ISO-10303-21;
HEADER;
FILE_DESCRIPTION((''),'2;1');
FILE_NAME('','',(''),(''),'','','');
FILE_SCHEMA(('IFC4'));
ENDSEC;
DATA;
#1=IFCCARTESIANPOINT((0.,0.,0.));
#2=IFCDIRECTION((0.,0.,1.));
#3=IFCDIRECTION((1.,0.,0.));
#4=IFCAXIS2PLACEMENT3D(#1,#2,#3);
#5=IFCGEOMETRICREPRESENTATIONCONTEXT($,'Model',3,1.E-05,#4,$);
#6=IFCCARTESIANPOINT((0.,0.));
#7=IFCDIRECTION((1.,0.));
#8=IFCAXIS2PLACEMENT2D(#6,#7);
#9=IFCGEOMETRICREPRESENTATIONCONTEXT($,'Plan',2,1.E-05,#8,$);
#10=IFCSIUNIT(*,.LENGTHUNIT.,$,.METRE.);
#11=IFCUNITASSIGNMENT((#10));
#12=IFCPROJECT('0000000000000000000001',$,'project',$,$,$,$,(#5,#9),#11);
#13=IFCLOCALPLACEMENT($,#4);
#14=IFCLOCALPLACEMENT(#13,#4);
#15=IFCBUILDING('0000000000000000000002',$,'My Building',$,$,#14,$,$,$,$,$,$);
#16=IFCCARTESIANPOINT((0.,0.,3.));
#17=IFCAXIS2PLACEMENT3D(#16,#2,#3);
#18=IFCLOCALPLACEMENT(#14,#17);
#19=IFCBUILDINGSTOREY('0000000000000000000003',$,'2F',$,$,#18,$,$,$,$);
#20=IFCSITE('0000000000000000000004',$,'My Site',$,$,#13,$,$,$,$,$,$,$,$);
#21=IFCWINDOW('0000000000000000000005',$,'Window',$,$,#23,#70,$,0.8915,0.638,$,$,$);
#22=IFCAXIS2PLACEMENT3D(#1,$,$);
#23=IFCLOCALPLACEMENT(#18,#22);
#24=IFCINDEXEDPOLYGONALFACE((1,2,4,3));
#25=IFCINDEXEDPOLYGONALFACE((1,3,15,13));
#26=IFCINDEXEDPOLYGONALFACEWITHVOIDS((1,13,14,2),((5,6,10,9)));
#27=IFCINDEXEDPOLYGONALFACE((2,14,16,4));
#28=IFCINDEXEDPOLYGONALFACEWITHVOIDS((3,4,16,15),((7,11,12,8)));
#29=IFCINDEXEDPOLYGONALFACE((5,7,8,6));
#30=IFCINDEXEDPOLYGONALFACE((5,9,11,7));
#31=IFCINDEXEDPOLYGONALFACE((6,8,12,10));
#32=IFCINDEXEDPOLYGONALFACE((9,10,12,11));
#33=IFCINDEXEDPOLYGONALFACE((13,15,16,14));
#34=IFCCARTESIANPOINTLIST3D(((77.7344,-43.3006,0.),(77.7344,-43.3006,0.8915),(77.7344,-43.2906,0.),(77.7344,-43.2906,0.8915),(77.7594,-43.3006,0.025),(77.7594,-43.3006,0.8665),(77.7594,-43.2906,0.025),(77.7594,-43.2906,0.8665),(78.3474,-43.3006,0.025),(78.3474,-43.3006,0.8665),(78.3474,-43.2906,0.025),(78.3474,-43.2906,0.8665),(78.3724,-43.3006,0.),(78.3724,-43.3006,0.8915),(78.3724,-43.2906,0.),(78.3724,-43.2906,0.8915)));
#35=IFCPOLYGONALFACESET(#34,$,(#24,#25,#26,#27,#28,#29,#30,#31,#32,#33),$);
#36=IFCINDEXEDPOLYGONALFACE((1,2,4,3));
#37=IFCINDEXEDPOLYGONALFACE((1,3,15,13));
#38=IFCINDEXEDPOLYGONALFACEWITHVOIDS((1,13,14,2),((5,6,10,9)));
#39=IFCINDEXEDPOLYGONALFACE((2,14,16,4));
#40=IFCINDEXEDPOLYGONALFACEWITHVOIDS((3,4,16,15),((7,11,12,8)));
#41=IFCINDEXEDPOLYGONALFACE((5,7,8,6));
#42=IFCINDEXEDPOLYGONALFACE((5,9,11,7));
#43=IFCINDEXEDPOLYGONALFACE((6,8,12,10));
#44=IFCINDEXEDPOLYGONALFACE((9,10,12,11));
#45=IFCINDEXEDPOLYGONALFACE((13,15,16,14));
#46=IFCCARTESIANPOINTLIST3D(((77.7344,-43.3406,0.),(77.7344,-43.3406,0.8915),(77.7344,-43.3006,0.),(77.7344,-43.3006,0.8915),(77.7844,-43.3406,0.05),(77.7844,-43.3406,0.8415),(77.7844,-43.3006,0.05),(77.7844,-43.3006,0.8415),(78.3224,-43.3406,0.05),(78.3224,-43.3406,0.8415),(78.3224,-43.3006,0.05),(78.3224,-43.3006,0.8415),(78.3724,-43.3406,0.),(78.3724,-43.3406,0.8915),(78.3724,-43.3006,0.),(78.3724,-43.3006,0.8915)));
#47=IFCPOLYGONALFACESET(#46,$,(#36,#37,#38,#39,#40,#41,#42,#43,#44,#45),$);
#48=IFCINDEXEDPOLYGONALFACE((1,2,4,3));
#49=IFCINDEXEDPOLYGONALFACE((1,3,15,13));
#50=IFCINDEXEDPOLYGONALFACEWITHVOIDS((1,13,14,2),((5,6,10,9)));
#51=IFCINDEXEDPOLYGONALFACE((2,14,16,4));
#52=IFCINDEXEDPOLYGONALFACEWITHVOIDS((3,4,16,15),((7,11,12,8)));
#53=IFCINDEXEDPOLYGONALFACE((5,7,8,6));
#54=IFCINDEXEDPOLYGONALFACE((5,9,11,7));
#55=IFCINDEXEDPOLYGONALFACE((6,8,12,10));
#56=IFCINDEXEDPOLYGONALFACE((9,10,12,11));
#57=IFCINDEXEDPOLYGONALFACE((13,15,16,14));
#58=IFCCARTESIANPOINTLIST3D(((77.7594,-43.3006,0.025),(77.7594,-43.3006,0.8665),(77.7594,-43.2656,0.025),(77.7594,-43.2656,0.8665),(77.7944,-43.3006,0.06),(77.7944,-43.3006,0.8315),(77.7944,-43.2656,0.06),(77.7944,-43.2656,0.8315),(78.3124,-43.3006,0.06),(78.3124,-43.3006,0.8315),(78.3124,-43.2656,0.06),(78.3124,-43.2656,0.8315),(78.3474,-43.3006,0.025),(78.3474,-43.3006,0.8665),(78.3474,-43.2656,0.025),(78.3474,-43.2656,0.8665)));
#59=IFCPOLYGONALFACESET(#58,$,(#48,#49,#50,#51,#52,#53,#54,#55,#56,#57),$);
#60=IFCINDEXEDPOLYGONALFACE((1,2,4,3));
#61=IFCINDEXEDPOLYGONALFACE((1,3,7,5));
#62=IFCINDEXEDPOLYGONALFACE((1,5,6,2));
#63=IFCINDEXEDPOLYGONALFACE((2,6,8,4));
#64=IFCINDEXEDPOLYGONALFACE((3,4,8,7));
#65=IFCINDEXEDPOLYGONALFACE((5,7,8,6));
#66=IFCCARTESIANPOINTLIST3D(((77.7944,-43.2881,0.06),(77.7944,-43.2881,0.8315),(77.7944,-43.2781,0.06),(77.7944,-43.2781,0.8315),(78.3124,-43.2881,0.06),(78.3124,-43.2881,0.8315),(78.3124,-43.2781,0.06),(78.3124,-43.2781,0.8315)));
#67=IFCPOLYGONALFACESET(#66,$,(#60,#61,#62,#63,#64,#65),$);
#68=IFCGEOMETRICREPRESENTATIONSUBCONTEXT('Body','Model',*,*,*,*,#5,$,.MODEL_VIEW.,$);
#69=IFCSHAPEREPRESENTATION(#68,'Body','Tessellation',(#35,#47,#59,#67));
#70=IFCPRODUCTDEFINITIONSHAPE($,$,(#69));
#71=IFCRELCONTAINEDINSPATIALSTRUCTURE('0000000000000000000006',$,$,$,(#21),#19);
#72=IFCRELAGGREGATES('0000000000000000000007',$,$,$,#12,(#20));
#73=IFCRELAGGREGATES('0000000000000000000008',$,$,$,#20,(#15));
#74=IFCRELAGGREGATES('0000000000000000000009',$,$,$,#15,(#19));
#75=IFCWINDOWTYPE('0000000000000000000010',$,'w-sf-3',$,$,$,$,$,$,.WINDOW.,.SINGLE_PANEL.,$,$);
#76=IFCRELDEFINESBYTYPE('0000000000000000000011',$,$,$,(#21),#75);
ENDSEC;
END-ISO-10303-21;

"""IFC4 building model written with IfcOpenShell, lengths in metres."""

from ifc_helpers import new_model, entity, si_unit, frame, origin_with_axes, origin_2d_with_axis, place, context, subcontext, project, spatial, line, indexed_curve, outline, extrude, shape, source, transform, mapped, type_object, type_shapes, element, save


model = new_model("IFC4")

# Units and contexts
model_context = context("Model", 3, precision=1e-05, world=origin_with_axes())
plan_context = context("Plan", 2, precision=1e-05, world=origin_2d_with_axis())
body_context_1 = subcontext(model_context, "Body", "Model", "MODEL_VIEW")
body_context_2 = subcontext(plan_context, "Body", "Plan", "PLAN_VIEW")
ifc_project = project(units=[si_unit("LENGTHUNIT", "METRE")], contexts=[model_context, plan_context])

# Site, building, storey
site_placement = place(None, origin_with_axes())
site = spatial("IfcSite", under=ifc_project, at=site_placement, Name="My Site")
building_placement = place(site_placement, origin_with_axes())
building = spatial("IfcBuilding", under=site, at=building_placement, Name="My Building")
storey_placement = place(building_placement, frame((0.0, 0.0, 3.0), z_axis=(0.0, 0.0, 1.0), x_axis=(1.0, 0.0, 0.0)))
storey = spatial("IfcBuildingStorey", under=building, at=storey_placement, Name="2F")

# Window
window_type_1 = type_object("IfcWindowType", Name="w-sf-3", PartitioningType="SINGLE_PANEL", PredefinedType="WINDOW")
shared_shape_1 = source(origin_with_axes(), body_context_1, "Body", "SweptSolid", [
    extrude(outline(indexed_curve([(0.0, 0.0), (0.638, 0.0), (0.638, 0.8915), (0.0, 0.8915)], segments=[line(1, 2, 3, 4, 1)]), holes=[indexed_curve([(0.025, 0.025), (0.613, 0.025), (0.613, 0.8665), (0.025, 0.8665)], segments=[line(1, 2, 3, 4, 1)])]), frame((0.0, 0.09, 0.0), z_axis=(0.0, -1.0, 0.0), x_axis=(1.0, 0.0, 0.0)), (0.0, 0.0, -1.0), 0.01),
    extrude(outline(indexed_curve([(0.0, 0.0), (0.638, 0.0), (0.638, 0.8915), (0.0, 0.8915)], segments=[line(1, 2, 3, 4, 1)]), holes=[indexed_curve([(0.05, 0.05), (0.588, 0.05), (0.588, 0.8415), (0.05, 0.8415)], segments=[line(1, 2, 3, 4, 1)])]), frame((0.0, 0.05, 0.0), z_axis=(0.0, -1.0, 0.0), x_axis=(1.0, 0.0, 0.0)), (0.0, 0.0, -1.0), 0.04),
    extrude(outline(indexed_curve([(0.0, 0.0), (0.588, 0.0), (0.588, 0.8415), (0.0, 0.8415)], segments=[line(1, 2, 3, 4, 1)]), holes=[indexed_curve([(0.035, 0.035), (0.553, 0.035), (0.553, 0.8065), (0.035, 0.8065)], segments=[line(1, 2, 3, 4, 1)])]), frame((0.025, 0.09, 0.025), z_axis=(0.0, -1.0, 0.0), x_axis=(1.0, 0.0, 0.0)), (0.0, 0.0, -1.0), 0.035),
    extrude(outline(indexed_curve([(0.035, 0.035), (0.553, 0.035), (0.553, 0.8065), (0.035, 0.8065)], segments=[line(1, 2, 3, 4, 1)])), frame((0.025, 0.1025, 0.025), z_axis=(0.0, -1.0, 0.0), x_axis=(1.0, 0.0, 0.0)), (0.0, 0.0, -1.0), 0.01),
])
shared_shape_2 = source(origin_with_axes(), body_context_2, "Body", "Curve2D", [
    entity("IfcIndexedPolyCurve", entity("IfcCartesianPointList2D", [[0.05, 0.05], [0.588, 0.05]])),
    entity("IfcIndexedPolyCurve", entity("IfcCartesianPointList2D", [[0.0, 0.1], [0.025, 0.1], [0.025, 0.09], [0.05, 0.09], [0.05, 0.05], [0.0, 0.05]]), [entity("IfcLineIndex", [1, 2, 3, 4, 5, 6, 1])]),
    entity("IfcIndexedPolyCurve", entity("IfcCartesianPointList2D", [[0.638, 0.1], [0.613, 0.1], [0.613, 0.09], [0.588, 0.09], [0.588, 0.05], [0.638, 0.05]]), [entity("IfcLineIndex", [1, 2, 3, 4, 5, 6, 1])]),
    entity("IfcIndexedPolyCurve", entity("IfcCartesianPointList2D", [[0.025, 0.09], [0.06, 0.09], [0.06, 0.125], [0.025, 0.125]]), [entity("IfcLineIndex", [1, 2, 3, 4, 1])]),
    entity("IfcIndexedPolyCurve", entity("IfcCartesianPointList2D", [[0.613, 0.09], [0.578, 0.09], [0.578, 0.125], [0.613, 0.125]]), [entity("IfcLineIndex", [1, 2, 3, 4, 1])]),
    entity("IfcIndexedPolyCurve", entity("IfcCartesianPointList2D", [[0.06, 0.09], [0.578, 0.09]])),
    entity("IfcIndexedPolyCurve", entity("IfcCartesianPointList2D", [[0.06, 0.125], [0.578, 0.125]])),
    entity("IfcIndexedPolyCurve", entity("IfcCartesianPointList2D", [[0.06, 0.1075], [0.578, 0.1075]])),
])
type_shapes(window_type_1, [shared_shape_1, shared_shape_2])
window_1_placement = place(storey_placement, frame((77.7344, -43.3906, 0.0), z_axis=(0.0, 0.0, 1.0), x_axis=(1.0, 0.0, 0.0)))
element("IfcWindow", 1, at=window_1_placement, inside=storey, type_object=window_type_1, Name="Window", OverallHeight=0.8915, OverallWidth=0.638, shapes=[
    shape(body_context_1, "Body", "MappedRepresentation", [mapped(shared_shape_1, transform((0.0, 0.0, 0.0), x_axis=(1.0, 0.0, 0.0), y_axis=(0.0, 1.0, 0.0), z_axis=(0.0, 0.0, 1.0), scale=1.0))]),
    shape(body_context_2, "Body", "MappedRepresentation", [mapped(shared_shape_2, transform((0.0, 0.0, 0.0), x_axis=(1.0, 0.0, 0.0), y_axis=(0.0, 1.0, 0.0), z_axis=(0.0, 0.0, 1.0), scale=1.0))]),
])

save(model, "model.ifc")
